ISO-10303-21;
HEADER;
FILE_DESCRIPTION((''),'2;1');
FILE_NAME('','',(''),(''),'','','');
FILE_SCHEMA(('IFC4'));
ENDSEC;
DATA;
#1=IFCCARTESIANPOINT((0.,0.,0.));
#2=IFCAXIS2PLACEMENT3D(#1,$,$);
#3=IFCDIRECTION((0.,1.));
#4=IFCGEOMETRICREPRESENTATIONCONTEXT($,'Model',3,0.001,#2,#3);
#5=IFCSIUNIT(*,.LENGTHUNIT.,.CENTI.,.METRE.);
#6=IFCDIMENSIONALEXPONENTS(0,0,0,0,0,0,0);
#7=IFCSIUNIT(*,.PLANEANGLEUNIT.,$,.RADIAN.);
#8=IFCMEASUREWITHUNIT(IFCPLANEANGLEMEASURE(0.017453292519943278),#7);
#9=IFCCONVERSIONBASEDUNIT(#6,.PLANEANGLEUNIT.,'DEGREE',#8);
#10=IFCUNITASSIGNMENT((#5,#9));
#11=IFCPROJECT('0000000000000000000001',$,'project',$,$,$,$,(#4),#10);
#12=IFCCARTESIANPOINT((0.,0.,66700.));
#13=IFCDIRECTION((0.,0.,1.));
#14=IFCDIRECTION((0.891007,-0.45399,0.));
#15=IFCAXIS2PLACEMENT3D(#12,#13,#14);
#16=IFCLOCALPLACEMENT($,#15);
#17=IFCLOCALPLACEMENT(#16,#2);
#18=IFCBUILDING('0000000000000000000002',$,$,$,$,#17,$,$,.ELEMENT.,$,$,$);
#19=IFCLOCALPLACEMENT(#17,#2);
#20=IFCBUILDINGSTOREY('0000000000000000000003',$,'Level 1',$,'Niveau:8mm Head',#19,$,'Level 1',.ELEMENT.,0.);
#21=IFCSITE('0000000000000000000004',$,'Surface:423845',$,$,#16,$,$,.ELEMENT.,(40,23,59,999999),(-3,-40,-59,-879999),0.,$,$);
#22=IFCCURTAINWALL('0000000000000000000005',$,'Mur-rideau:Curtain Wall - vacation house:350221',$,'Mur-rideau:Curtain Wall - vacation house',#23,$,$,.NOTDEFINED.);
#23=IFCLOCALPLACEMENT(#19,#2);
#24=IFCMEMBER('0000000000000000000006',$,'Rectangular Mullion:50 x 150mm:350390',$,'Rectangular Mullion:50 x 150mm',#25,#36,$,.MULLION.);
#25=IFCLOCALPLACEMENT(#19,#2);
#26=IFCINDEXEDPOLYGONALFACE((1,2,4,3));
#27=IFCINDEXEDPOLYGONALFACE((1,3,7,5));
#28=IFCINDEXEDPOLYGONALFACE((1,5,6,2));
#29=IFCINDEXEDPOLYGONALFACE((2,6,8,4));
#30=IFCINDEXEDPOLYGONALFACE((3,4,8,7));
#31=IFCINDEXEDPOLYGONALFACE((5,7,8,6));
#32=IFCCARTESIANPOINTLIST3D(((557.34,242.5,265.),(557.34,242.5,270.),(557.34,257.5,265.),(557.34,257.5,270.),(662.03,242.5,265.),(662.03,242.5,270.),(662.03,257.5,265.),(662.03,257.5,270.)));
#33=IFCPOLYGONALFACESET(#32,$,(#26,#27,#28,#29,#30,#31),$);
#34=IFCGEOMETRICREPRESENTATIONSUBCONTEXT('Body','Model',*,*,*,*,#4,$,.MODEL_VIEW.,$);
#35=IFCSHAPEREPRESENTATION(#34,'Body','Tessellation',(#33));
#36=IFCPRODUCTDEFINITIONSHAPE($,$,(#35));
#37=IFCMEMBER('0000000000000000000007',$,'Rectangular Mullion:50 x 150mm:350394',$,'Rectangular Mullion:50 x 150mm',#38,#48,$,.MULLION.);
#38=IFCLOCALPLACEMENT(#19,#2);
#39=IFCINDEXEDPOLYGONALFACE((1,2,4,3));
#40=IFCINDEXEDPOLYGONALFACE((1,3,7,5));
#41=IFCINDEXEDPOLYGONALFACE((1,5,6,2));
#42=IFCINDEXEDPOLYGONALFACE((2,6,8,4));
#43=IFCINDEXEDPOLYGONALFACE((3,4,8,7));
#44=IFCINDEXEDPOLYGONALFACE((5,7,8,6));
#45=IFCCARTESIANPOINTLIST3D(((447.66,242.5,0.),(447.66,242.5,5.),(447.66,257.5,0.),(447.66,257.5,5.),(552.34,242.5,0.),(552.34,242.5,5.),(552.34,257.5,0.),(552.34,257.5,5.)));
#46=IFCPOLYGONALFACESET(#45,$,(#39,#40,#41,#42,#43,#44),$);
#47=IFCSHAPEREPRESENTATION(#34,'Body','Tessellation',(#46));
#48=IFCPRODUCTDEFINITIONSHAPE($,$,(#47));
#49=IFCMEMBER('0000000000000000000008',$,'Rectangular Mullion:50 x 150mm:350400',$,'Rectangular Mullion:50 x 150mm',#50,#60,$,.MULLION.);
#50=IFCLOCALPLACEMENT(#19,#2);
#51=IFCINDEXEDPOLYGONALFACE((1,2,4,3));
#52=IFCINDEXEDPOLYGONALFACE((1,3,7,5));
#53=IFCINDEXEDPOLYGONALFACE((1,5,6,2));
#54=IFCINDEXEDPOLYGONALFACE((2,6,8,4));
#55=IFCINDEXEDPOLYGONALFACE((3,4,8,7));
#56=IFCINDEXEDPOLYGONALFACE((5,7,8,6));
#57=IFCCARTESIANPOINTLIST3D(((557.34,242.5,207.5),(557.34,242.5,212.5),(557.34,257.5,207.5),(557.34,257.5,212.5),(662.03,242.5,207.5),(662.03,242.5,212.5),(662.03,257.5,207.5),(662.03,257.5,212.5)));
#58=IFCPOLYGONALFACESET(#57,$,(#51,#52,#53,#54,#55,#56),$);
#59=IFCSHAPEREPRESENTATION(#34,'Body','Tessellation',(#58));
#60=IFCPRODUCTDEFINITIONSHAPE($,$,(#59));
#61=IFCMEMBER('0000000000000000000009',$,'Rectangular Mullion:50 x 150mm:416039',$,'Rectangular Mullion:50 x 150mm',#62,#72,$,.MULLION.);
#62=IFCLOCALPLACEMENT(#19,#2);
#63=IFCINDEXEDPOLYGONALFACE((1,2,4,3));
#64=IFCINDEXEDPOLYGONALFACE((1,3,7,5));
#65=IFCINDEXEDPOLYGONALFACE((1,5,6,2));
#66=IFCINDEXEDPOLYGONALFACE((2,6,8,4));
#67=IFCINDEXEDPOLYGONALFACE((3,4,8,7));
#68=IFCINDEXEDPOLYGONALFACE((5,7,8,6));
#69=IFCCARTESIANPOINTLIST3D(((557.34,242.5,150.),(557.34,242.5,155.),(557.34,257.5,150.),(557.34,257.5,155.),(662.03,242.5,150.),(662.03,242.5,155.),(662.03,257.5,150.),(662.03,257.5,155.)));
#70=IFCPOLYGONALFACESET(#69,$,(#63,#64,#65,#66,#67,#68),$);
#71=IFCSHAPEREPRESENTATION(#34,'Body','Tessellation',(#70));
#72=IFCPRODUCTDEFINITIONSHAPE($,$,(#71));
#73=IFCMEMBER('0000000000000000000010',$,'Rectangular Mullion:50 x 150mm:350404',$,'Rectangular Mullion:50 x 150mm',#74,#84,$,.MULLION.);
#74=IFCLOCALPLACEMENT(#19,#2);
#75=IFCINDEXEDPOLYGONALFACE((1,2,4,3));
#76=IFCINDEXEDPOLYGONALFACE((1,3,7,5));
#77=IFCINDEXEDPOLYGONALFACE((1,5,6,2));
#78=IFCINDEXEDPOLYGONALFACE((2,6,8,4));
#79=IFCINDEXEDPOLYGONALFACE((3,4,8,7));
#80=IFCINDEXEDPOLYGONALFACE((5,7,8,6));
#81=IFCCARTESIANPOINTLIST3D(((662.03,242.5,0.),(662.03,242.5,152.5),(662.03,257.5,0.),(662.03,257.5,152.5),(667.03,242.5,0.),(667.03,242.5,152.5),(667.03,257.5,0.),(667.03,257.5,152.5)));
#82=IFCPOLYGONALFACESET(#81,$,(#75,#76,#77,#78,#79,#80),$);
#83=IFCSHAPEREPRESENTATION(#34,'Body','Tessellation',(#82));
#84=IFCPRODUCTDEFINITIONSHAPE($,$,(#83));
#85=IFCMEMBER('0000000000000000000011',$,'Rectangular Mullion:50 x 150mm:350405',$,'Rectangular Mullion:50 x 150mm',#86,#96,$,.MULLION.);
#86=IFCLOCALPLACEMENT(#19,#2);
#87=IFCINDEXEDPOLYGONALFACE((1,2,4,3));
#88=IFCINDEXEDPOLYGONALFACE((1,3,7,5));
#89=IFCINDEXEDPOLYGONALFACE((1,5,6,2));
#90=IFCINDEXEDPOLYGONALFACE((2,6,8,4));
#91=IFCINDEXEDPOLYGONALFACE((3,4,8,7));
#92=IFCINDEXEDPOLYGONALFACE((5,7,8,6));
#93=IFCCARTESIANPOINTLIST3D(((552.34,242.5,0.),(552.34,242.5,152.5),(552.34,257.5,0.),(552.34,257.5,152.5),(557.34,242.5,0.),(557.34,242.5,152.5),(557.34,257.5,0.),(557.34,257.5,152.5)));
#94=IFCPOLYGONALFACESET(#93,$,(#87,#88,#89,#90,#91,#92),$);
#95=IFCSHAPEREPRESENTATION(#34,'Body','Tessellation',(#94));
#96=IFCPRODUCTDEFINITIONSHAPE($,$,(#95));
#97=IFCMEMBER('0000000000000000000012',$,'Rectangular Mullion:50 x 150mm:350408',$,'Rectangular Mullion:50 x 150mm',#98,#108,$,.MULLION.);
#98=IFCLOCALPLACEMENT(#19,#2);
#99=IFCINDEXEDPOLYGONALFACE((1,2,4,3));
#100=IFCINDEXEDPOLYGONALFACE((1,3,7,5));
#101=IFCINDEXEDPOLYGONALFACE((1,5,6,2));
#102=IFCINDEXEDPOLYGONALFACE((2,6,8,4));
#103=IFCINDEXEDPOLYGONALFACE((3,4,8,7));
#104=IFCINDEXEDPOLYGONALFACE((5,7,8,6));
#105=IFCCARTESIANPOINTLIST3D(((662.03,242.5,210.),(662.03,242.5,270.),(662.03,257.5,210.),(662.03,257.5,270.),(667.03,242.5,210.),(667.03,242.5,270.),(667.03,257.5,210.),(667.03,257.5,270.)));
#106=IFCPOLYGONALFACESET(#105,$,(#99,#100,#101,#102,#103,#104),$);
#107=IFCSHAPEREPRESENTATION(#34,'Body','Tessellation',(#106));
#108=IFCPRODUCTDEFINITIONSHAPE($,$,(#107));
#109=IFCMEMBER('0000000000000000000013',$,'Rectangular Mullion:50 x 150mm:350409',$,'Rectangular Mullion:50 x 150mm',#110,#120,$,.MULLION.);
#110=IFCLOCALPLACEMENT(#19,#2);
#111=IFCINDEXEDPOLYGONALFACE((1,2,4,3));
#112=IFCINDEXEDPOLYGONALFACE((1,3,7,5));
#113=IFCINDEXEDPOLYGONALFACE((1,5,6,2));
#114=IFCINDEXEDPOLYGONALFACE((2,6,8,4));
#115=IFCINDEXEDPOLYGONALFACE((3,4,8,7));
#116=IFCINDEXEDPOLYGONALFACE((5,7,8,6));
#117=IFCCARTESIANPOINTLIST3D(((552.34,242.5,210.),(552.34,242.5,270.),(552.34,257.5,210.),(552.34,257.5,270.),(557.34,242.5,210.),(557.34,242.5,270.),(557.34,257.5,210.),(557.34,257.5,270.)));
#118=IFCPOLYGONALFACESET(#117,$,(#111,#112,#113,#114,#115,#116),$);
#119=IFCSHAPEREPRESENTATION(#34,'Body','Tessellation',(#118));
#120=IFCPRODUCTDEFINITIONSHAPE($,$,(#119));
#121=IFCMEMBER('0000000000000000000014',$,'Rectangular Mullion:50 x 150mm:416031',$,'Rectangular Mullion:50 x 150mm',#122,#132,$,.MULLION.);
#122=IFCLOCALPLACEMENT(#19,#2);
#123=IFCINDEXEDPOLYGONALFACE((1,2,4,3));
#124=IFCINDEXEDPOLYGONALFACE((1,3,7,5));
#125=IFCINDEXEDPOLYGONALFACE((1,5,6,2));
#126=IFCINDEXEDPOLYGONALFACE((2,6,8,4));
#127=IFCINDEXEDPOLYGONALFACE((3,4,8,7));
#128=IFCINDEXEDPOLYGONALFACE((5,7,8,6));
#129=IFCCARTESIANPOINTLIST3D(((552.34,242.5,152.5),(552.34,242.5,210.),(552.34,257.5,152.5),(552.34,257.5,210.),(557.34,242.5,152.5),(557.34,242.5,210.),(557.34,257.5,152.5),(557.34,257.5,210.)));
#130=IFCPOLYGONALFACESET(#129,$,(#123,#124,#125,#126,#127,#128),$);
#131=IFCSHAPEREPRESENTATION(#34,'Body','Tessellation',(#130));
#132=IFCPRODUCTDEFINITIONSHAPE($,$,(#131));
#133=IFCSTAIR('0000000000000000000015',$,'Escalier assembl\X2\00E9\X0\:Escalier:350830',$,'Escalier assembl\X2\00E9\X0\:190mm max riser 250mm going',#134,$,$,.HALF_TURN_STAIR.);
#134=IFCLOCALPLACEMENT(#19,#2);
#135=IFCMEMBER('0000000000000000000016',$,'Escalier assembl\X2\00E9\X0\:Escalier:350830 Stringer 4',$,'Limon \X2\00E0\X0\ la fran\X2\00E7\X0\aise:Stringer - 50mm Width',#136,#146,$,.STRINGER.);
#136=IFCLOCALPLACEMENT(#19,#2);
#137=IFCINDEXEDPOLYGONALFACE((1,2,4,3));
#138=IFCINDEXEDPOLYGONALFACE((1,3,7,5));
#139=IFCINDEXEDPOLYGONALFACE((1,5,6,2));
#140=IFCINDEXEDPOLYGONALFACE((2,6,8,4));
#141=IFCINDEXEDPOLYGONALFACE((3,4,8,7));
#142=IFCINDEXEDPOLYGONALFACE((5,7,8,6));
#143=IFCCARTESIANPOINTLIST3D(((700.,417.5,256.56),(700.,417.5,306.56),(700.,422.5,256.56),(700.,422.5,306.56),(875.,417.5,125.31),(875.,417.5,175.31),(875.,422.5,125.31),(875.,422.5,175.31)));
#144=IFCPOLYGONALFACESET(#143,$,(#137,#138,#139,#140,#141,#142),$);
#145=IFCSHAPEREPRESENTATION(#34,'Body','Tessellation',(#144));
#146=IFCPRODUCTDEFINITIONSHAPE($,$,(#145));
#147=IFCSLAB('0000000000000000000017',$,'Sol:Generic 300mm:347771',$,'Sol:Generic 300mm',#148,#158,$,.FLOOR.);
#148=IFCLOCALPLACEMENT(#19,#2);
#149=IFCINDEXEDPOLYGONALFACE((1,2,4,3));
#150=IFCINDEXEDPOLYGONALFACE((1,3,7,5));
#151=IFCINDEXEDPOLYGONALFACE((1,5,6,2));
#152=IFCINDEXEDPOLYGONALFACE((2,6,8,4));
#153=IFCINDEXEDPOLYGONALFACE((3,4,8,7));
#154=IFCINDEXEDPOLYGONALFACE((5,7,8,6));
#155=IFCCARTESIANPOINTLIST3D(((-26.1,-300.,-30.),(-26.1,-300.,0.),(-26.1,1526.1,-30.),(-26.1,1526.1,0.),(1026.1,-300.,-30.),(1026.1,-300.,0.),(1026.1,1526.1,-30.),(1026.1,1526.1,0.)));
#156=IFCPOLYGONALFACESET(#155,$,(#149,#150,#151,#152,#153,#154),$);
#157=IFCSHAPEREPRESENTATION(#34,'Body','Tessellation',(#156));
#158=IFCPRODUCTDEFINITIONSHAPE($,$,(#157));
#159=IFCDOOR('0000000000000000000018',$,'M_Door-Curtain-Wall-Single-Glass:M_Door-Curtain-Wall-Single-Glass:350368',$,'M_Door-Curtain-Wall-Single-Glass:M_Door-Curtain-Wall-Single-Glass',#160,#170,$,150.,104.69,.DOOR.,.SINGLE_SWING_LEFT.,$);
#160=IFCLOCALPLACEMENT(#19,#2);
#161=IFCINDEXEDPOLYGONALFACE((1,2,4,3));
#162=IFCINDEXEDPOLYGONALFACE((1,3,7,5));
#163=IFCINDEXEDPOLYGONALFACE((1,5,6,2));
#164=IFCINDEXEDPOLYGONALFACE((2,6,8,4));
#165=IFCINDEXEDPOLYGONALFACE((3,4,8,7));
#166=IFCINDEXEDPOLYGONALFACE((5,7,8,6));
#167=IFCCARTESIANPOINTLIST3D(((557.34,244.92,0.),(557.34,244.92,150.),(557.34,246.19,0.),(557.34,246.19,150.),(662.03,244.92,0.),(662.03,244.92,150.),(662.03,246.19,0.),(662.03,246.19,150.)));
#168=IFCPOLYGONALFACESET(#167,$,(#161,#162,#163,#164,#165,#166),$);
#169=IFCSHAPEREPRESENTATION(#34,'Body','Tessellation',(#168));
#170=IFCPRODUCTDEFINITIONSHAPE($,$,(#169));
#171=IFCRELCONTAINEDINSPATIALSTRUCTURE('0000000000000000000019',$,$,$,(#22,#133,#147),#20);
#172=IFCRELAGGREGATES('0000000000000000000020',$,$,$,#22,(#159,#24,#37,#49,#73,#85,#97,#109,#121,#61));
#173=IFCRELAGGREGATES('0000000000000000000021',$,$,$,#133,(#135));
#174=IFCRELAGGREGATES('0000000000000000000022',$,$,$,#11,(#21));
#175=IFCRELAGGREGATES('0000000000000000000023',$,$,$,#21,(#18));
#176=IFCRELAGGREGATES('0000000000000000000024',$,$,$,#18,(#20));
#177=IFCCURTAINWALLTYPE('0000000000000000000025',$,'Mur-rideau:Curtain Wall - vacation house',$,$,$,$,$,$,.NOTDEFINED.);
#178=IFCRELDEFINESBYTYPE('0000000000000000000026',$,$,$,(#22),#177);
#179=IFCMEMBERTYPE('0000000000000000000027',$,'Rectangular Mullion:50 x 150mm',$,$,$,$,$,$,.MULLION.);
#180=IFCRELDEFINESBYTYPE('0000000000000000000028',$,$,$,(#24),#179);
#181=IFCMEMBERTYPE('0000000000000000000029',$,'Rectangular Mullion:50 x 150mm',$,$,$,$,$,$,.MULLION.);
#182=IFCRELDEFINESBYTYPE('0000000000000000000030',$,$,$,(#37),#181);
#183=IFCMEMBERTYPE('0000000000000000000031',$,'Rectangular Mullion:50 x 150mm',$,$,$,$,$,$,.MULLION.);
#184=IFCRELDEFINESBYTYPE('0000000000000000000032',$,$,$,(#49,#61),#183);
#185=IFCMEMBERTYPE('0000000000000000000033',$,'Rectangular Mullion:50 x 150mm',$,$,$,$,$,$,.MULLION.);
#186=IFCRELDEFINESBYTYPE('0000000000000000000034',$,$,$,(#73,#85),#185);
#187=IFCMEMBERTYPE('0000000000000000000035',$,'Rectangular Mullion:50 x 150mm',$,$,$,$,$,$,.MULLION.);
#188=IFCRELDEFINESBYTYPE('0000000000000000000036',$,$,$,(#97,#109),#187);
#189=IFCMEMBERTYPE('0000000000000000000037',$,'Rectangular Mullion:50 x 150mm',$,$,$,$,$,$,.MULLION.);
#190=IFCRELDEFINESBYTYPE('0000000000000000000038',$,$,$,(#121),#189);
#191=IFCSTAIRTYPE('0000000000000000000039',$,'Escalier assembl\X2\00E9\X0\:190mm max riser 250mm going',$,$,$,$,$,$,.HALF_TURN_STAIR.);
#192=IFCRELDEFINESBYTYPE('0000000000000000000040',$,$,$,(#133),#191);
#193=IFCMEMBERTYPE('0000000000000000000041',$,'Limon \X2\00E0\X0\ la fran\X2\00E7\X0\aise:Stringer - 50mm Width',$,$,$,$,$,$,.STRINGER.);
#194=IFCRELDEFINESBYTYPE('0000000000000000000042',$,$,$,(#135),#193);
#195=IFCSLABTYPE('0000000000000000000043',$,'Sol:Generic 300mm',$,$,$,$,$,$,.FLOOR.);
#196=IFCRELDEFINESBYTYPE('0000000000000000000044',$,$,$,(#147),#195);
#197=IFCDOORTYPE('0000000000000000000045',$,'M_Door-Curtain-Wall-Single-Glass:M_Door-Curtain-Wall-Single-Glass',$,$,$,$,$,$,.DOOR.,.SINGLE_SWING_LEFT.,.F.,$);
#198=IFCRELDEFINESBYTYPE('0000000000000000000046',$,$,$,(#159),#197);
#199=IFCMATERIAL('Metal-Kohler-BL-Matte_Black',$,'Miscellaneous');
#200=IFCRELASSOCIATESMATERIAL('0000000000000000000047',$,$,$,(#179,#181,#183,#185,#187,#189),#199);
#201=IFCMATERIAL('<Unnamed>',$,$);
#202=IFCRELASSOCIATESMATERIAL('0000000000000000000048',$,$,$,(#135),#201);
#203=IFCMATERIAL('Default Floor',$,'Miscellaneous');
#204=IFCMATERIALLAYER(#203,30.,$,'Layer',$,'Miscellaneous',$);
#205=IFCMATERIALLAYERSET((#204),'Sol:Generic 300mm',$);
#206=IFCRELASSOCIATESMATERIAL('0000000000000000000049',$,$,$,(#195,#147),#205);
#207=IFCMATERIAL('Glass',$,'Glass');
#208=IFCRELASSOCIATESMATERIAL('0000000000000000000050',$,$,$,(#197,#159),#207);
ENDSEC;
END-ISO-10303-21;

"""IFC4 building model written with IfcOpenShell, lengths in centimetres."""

from ifc_helpers import new_model, entity, si_unit, converted_unit, direction, frame, frame_2d, origin, origin_2d_with_axis, place, context, subcontext, project, spatial, polyline, rectangle, outline, extrude, source, transform, mapped, material, layer, layer_set, layer_usage, material_profile, profile_set, type_object, type_shapes, element, aggregate, save


model = new_model("IFC4")

# Units and contexts
model_context = context("Model", 3, precision=0.001, world=origin(), true_north=direction((0.0, 1.0)))
body_context = subcontext(model_context, "Body", "Model", "MODEL_VIEW")
ifc_project = project(units=[si_unit("LENGTHUNIT", "METRE", prefix="CENTI"), converted_unit("PLANEANGLEUNIT", "DEGREE", entity("IfcPlaneAngleMeasure", 0.017453292519943278), si_unit("PLANEANGLEUNIT", "RADIAN"), dimensions=[0, 0, 0, 0, 0, 0, 0])], contexts=[model_context])

# Site, building, storey
site_placement = place(None, frame((0.0, 0.0, 66700.0), z_axis=(0.0, 0.0, 1.0), x_axis=(0.891007, -0.45399, 0.0)))
site = spatial("IfcSite", under=ifc_project, at=site_placement, Name="Surface:423845", CompositionType="ELEMENT", RefLatitude=(40, 23, 59, 999999), RefLongitude=(-3, -40, -59, -879999), RefElevation=0.0)
building_placement = place(site_placement, origin())
building = spatial("IfcBuilding", under=site, at=building_placement, CompositionType="ELEMENT")
storey_placement = place(building_placement, origin())
storey = spatial("IfcBuildingStorey", under=building, at=storey_placement, Name="Level 1", ObjectType="Niveau:8mm Head", LongName="Level 1", CompositionType="ELEMENT", Elevation=0.0)

# Curtain wall, members
curtain_wall_type = type_object("IfcCurtainWallType", Name="Mur-rideau:Curtain Wall - vacation house", PredefinedType="NOTDEFINED")
curtain_wall_placement = place(storey_placement, origin())
curtain_wall = element("IfcCurtainWall", 1, at=curtain_wall_placement, inside=storey, type_object=curtain_wall_type, Name="Mur-rideau:Curtain Wall - vacation house:350221", ObjectType="Mur-rideau:Curtain Wall - vacation house", PredefinedType="NOTDEFINED")
ifc_material_1 = material(Name="Metal-Kohler-BL-Matte_Black", Category="Miscellaneous")
ifc_material_profile_1 = material_profile(ifc_material_1, rectangle(XDim=5.0, YDim=15.0, at=origin_2d_with_axis()), Name="50 x 150mm")
ifc_profile_set_1 = profile_set([ifc_material_profile_1], Name="50 x 150mm")
member_type_1 = type_object("IfcMemberType", Name="Rectangular Mullion:50 x 150mm", PredefinedType="MULLION", material=ifc_profile_set_1)
shared_shape_1 = source(origin(), body_context, "Body", "SweptSolid", [
    extrude(rectangle(XDim=5.0, YDim=15.0, at=origin_2d_with_axis()), frame((-2.5, 0.0, -104.69), z_axis=(0.0, 0.0, 1.0), x_axis=(-1.0, 0.0, 0.0)), (0.0, 0.0, 1.0), 104.69),
])
type_shapes(member_type_1, [shared_shape_1])
member_1_placement = place(curtain_wall_placement, frame((557.34, 250.0, 270.0), z_axis=(-1.0, 0.0, 0.0), x_axis=(0.0, 0.0, 1.0)))
member_1 = element("IfcMember", 2, at=member_1_placement, type_object=member_type_1, Name="Rectangular Mullion:50 x 150mm:350390", ObjectType="Rectangular Mullion:50 x 150mm", PredefinedType="MULLION", context=body_context, shape_type="MappedRepresentation", body=[
    mapped(shared_shape_1, transform((0.0, 0.0, 0.0), scale=1.0)),
])
member_type_2 = type_object("IfcMemberType", Name="Rectangular Mullion:50 x 150mm", PredefinedType="MULLION", material=ifc_profile_set_1)
shared_shape_2 = source(origin(), body_context, "Body", "SweptSolid", [
    extrude(rectangle(XDim=5.0, YDim=15.0, at=origin_2d_with_axis()), frame((-2.5, 0.0, -104.69), z_axis=(0.0, 0.0, 1.0), x_axis=(-1.0, 0.0, 0.0)), (0.0, 0.0, 1.0), 104.69),
])
type_shapes(member_type_2, [shared_shape_2])
member_2_placement = place(curtain_wall_placement, frame((552.34, 250.0, 0.0), z_axis=(1.0, 0.0, 0.0), x_axis=(0.0, 0.0, -1.0)))
member_2 = element("IfcMember", 3, at=member_2_placement, type_object=member_type_2, Name="Rectangular Mullion:50 x 150mm:350394", ObjectType="Rectangular Mullion:50 x 150mm", PredefinedType="MULLION", context=body_context, shape_type="MappedRepresentation", body=[
    mapped(shared_shape_2, transform((0.0, 0.0, 0.0), scale=1.0)),
])
member_type_3 = type_object("IfcMemberType", Name="Rectangular Mullion:50 x 150mm", PredefinedType="MULLION", material=ifc_profile_set_1)
shared_shape_3 = source(origin(), body_context, "Body", "SweptSolid", [
    extrude(rectangle(XDim=5.0, YDim=15.0, at=origin_2d_with_axis()), frame((0.0, 0.0, -104.69), z_axis=(0.0, 0.0, 1.0), x_axis=(-1.0, 0.0, 0.0)), (0.0, 0.0, 1.0), 104.69),
])
type_shapes(member_type_3, [shared_shape_3])
member_3_placement = place(curtain_wall_placement, frame((557.34, 250.0, 210.0), z_axis=(-1.0, 0.0, 0.0), x_axis=(0.0, 0.0, 1.0)))
member_3 = element("IfcMember", 4, at=member_3_placement, type_object=member_type_3, Name="Rectangular Mullion:50 x 150mm:350400", ObjectType="Rectangular Mullion:50 x 150mm", PredefinedType="MULLION", context=body_context, shape_type="MappedRepresentation", body=[
    mapped(shared_shape_3, transform((0.0, 0.0, 0.0), scale=1.0)),
])
member_4_placement = place(curtain_wall_placement, frame((557.34, 250.0, 152.5), z_axis=(-1.0, 0.0, 0.0), x_axis=(0.0, 0.0, 1.0)))
member_4 = element("IfcMember", 5, at=member_4_placement, type_object=member_type_3, Name="Rectangular Mullion:50 x 150mm:416039", ObjectType="Rectangular Mullion:50 x 150mm", PredefinedType="MULLION", context=body_context, shape_type="MappedRepresentation", body=[
    mapped(shared_shape_3, transform((0.0, 0.0, 0.0), scale=1.0)),
])
member_type_4 = type_object("IfcMemberType", Name="Rectangular Mullion:50 x 150mm", PredefinedType="MULLION", material=ifc_profile_set_1)
shared_shape_4 = source(origin(), body_context, "Body", "SweptSolid", [
    extrude(rectangle(XDim=5.0, YDim=15.0, at=origin_2d_with_axis()), frame((0.0, 0.0, -152.5), z_axis=(0.0, 0.0, 1.0), x_axis=(-1.0, 0.0, 0.0)), (0.0, 0.0, 1.0), 152.5),
])
type_shapes(member_type_4, [shared_shape_4])
member_5_placement = place(curtain_wall_placement, frame((664.53, 250.0, 0.0), z_axis=(0.0, 0.0, -1.0), x_axis=(-1.0, 0.0, 0.0)))
member_5 = element("IfcMember", 6, at=member_5_placement, type_object=member_type_4, Name="Rectangular Mullion:50 x 150mm:350404", ObjectType="Rectangular Mullion:50 x 150mm", PredefinedType="MULLION", context=body_context, shape_type="MappedRepresentation", body=[
    mapped(shared_shape_4, transform((0.0, 0.0, 0.0), scale=1.0)),
])
member_6_placement = place(curtain_wall_placement, frame((554.84, 250.0, 0.0), z_axis=(0.0, 0.0, -1.0), x_axis=(-1.0, 0.0, 0.0)))
member_6 = element("IfcMember", 7, at=member_6_placement, type_object=member_type_4, Name="Rectangular Mullion:50 x 150mm:350405", ObjectType="Rectangular Mullion:50 x 150mm", PredefinedType="MULLION", context=body_context, shape_type="MappedRepresentation", body=[
    mapped(shared_shape_4, transform((0.0, 0.0, 0.0), scale=1.0)),
])
member_type_5 = type_object("IfcMemberType", Name="Rectangular Mullion:50 x 150mm", PredefinedType="MULLION", material=ifc_profile_set_1)
shared_shape_5 = source(origin(), body_context, "Body", "SweptSolid", [
    extrude(rectangle(XDim=5.0, YDim=15.0, at=origin_2d_with_axis()), frame((0.0, 0.0, -60.0), z_axis=(0.0, 0.0, 1.0), x_axis=(-1.0, 0.0, 0.0)), (0.0, 0.0, 1.0), 60.0),
])
type_shapes(member_type_5, [shared_shape_5])
member_7_placement = place(curtain_wall_placement, frame((664.53, 250.0, 210.0), z_axis=(0.0, 0.0, -1.0), x_axis=(-1.0, 0.0, 0.0)))
member_7 = element("IfcMember", 8, at=member_7_placement, type_object=member_type_5, Name="Rectangular Mullion:50 x 150mm:350408", ObjectType="Rectangular Mullion:50 x 150mm", PredefinedType="MULLION", context=body_context, shape_type="MappedRepresentation", body=[
    mapped(shared_shape_5, transform((0.0, 0.0, 0.0), scale=1.0)),
])
member_8_placement = place(curtain_wall_placement, frame((554.84, 250.0, 210.0), z_axis=(0.0, 0.0, -1.0), x_axis=(-1.0, 0.0, 0.0)))
member_8 = element("IfcMember", 9, at=member_8_placement, type_object=member_type_5, Name="Rectangular Mullion:50 x 150mm:350409", ObjectType="Rectangular Mullion:50 x 150mm", PredefinedType="MULLION", context=body_context, shape_type="MappedRepresentation", body=[
    mapped(shared_shape_5, transform((0.0, 0.0, 0.0), scale=1.0)),
])
member_type_6 = type_object("IfcMemberType", Name="Rectangular Mullion:50 x 150mm", PredefinedType="MULLION", material=ifc_profile_set_1)
shared_shape_6 = source(origin(), body_context, "Body", "SweptSolid", [
    extrude(rectangle(XDim=5.0, YDim=15.0, at=origin_2d_with_axis()), frame((0.0, 0.0, -57.5), z_axis=(0.0, 0.0, 1.0), x_axis=(-1.0, 0.0, 0.0)), (0.0, 0.0, 1.0), 57.5),
])
type_shapes(member_type_6, [shared_shape_6])
member_9_placement = place(curtain_wall_placement, frame((554.84, 250.0, 152.5), z_axis=(0.0, 0.0, -1.0), x_axis=(-1.0, 0.0, 0.0)))
member_9 = element("IfcMember", 10, at=member_9_placement, type_object=member_type_6, Name="Rectangular Mullion:50 x 150mm:416031", ObjectType="Rectangular Mullion:50 x 150mm", PredefinedType="MULLION", context=body_context, shape_type="MappedRepresentation", body=[
    mapped(shared_shape_6, transform((0.0, 0.0, 0.0), scale=1.0)),
])

# Stair, member
stair_type = type_object("IfcStairType", Name="Escalier assemblé:190mm max riser 250mm going", PredefinedType="HALF_TURN_STAIR")
stair_placement = place(storey_placement, origin())
stair = element("IfcStair", 11, at=stair_placement, inside=storey, type_object=stair_type, Name="Escalier assemblé:Escalier:350830", ObjectType="Escalier assemblé:190mm max riser 250mm going", PredefinedType="HALF_TURN_STAIR")
ifc_material_2 = material(Name="<Unnamed>")
member_type_7 = type_object("IfcMemberType", Name="Limon à la française:Stringer - 50mm Width", PredefinedType="STRINGER")
member_10_placement = place(stair_placement, origin())
member_10 = element("IfcMember", 12, at=member_10_placement, type_object=member_type_7, material=ifc_material_2, Name="Escalier assemblé:Escalier:350830 Stringer 4", ObjectType="Limon à la française:Stringer - 50mm Width", PredefinedType="STRINGER", context=body_context, shape_type="SweptSolid", body=[
    extrude(outline(polyline([(-124.38, -20.0), (94.38, -20.0), (124.38, 20.0), (-94.38, 20.0), (-124.38, -20.0)])), frame((787.5, 417.5, 215.94), z_axis=(0.0, 1.0, 0.0), x_axis=(-0.8, 0.0, 0.6)), (0.0, 0.0, 1.0), 5.0),
])

# Slab
ifc_material_3 = material(Name="Default Floor", Category="Miscellaneous")
ifc_layer = layer(ifc_material_3, 30.0, Name="Layer", Category="Miscellaneous")
ifc_layer_set = layer_set([ifc_layer], Name="Sol:Generic 300mm")
ifc_layer_usage = layer_usage(ifc_layer_set, "AXIS3", "POSITIVE", 0.0)
slab_type_1 = type_object("IfcSlabType", Name="Sol:Generic 300mm", PredefinedType="FLOOR", material=ifc_layer_set)
slab_1_placement = place(storey_placement, origin())
element("IfcSlab", 13, at=slab_1_placement, inside=storey, type_object=slab_type_1, material=ifc_layer_usage, Name="Sol:Generic 300mm:347771", ObjectType="Sol:Generic 300mm", PredefinedType="FLOOR", context=body_context, shape_type="SweptSolid", body=[
    extrude(rectangle(XDim=1826.1, YDim=1052.2, at=frame_2d((0.0, 0.0), x_axis=(1.0, 0.0))), frame((500.0, 613.05, 0.0), z_axis=(0.0, 0.0, -1.0), x_axis=(0.0, 1.0, 0.0)), (0.0, 0.0, 1.0), 30.0),
])

# Shared definitions
ifc_material_4 = material(Name="Glass", Category="Glass")

# Door
door_type_1 = type_object("IfcDoorType", Name="M_Door-Curtain-Wall-Single-Glass:M_Door-Curtain-Wall-Single-Glass", OperationType="SINGLE_SWING_LEFT", ParameterTakesPrecedence=False, PredefinedType="DOOR", material=ifc_material_4)
shared_shape_7 = source(origin(), body_context, "Body", "SweptSolid", [
    extrude(rectangle(XDim=1.27, YDim=104.69, at=frame_2d((0.0, 0.0), x_axis=(1.0, 0.0))), frame((0.0, 4.45, 0.0), z_axis=(0.0, 0.0, 1.0), x_axis=(0.0, -1.0, 0.0)), (0.0, 0.0, 1.0), 150.0),
])
type_shapes(door_type_1, [shared_shape_7])
door_1_placement = place(curtain_wall_placement, frame((609.69, 250.0, 0.0), z_axis=(0.0, 0.0, 1.0), x_axis=(-1.0, 0.0, 0.0)))
door_1 = element("IfcDoor", 14, at=door_1_placement, type_object=door_type_1, material=ifc_material_4, Name="M_Door-Curtain-Wall-Single-Glass:M_Door-Curtain-Wall-Single-Glass:350368", ObjectType="M_Door-Curtain-Wall-Single-Glass:M_Door-Curtain-Wall-Single-Glass", OperationType="SINGLE_SWING_LEFT", OverallHeight=150.0, OverallWidth=104.69, PredefinedType="DOOR", context=body_context, shape_type="MappedRepresentation", body=[
    mapped(shared_shape_7, transform((0.0, 0.0, 0.0), scale=1.0)),
])
aggregate(curtain_wall, [door_1, member_1, member_2, member_3, member_5, member_6, member_7, member_8, member_9, member_4])

aggregate(stair, [member_10])

save(model, "model.ifc")
